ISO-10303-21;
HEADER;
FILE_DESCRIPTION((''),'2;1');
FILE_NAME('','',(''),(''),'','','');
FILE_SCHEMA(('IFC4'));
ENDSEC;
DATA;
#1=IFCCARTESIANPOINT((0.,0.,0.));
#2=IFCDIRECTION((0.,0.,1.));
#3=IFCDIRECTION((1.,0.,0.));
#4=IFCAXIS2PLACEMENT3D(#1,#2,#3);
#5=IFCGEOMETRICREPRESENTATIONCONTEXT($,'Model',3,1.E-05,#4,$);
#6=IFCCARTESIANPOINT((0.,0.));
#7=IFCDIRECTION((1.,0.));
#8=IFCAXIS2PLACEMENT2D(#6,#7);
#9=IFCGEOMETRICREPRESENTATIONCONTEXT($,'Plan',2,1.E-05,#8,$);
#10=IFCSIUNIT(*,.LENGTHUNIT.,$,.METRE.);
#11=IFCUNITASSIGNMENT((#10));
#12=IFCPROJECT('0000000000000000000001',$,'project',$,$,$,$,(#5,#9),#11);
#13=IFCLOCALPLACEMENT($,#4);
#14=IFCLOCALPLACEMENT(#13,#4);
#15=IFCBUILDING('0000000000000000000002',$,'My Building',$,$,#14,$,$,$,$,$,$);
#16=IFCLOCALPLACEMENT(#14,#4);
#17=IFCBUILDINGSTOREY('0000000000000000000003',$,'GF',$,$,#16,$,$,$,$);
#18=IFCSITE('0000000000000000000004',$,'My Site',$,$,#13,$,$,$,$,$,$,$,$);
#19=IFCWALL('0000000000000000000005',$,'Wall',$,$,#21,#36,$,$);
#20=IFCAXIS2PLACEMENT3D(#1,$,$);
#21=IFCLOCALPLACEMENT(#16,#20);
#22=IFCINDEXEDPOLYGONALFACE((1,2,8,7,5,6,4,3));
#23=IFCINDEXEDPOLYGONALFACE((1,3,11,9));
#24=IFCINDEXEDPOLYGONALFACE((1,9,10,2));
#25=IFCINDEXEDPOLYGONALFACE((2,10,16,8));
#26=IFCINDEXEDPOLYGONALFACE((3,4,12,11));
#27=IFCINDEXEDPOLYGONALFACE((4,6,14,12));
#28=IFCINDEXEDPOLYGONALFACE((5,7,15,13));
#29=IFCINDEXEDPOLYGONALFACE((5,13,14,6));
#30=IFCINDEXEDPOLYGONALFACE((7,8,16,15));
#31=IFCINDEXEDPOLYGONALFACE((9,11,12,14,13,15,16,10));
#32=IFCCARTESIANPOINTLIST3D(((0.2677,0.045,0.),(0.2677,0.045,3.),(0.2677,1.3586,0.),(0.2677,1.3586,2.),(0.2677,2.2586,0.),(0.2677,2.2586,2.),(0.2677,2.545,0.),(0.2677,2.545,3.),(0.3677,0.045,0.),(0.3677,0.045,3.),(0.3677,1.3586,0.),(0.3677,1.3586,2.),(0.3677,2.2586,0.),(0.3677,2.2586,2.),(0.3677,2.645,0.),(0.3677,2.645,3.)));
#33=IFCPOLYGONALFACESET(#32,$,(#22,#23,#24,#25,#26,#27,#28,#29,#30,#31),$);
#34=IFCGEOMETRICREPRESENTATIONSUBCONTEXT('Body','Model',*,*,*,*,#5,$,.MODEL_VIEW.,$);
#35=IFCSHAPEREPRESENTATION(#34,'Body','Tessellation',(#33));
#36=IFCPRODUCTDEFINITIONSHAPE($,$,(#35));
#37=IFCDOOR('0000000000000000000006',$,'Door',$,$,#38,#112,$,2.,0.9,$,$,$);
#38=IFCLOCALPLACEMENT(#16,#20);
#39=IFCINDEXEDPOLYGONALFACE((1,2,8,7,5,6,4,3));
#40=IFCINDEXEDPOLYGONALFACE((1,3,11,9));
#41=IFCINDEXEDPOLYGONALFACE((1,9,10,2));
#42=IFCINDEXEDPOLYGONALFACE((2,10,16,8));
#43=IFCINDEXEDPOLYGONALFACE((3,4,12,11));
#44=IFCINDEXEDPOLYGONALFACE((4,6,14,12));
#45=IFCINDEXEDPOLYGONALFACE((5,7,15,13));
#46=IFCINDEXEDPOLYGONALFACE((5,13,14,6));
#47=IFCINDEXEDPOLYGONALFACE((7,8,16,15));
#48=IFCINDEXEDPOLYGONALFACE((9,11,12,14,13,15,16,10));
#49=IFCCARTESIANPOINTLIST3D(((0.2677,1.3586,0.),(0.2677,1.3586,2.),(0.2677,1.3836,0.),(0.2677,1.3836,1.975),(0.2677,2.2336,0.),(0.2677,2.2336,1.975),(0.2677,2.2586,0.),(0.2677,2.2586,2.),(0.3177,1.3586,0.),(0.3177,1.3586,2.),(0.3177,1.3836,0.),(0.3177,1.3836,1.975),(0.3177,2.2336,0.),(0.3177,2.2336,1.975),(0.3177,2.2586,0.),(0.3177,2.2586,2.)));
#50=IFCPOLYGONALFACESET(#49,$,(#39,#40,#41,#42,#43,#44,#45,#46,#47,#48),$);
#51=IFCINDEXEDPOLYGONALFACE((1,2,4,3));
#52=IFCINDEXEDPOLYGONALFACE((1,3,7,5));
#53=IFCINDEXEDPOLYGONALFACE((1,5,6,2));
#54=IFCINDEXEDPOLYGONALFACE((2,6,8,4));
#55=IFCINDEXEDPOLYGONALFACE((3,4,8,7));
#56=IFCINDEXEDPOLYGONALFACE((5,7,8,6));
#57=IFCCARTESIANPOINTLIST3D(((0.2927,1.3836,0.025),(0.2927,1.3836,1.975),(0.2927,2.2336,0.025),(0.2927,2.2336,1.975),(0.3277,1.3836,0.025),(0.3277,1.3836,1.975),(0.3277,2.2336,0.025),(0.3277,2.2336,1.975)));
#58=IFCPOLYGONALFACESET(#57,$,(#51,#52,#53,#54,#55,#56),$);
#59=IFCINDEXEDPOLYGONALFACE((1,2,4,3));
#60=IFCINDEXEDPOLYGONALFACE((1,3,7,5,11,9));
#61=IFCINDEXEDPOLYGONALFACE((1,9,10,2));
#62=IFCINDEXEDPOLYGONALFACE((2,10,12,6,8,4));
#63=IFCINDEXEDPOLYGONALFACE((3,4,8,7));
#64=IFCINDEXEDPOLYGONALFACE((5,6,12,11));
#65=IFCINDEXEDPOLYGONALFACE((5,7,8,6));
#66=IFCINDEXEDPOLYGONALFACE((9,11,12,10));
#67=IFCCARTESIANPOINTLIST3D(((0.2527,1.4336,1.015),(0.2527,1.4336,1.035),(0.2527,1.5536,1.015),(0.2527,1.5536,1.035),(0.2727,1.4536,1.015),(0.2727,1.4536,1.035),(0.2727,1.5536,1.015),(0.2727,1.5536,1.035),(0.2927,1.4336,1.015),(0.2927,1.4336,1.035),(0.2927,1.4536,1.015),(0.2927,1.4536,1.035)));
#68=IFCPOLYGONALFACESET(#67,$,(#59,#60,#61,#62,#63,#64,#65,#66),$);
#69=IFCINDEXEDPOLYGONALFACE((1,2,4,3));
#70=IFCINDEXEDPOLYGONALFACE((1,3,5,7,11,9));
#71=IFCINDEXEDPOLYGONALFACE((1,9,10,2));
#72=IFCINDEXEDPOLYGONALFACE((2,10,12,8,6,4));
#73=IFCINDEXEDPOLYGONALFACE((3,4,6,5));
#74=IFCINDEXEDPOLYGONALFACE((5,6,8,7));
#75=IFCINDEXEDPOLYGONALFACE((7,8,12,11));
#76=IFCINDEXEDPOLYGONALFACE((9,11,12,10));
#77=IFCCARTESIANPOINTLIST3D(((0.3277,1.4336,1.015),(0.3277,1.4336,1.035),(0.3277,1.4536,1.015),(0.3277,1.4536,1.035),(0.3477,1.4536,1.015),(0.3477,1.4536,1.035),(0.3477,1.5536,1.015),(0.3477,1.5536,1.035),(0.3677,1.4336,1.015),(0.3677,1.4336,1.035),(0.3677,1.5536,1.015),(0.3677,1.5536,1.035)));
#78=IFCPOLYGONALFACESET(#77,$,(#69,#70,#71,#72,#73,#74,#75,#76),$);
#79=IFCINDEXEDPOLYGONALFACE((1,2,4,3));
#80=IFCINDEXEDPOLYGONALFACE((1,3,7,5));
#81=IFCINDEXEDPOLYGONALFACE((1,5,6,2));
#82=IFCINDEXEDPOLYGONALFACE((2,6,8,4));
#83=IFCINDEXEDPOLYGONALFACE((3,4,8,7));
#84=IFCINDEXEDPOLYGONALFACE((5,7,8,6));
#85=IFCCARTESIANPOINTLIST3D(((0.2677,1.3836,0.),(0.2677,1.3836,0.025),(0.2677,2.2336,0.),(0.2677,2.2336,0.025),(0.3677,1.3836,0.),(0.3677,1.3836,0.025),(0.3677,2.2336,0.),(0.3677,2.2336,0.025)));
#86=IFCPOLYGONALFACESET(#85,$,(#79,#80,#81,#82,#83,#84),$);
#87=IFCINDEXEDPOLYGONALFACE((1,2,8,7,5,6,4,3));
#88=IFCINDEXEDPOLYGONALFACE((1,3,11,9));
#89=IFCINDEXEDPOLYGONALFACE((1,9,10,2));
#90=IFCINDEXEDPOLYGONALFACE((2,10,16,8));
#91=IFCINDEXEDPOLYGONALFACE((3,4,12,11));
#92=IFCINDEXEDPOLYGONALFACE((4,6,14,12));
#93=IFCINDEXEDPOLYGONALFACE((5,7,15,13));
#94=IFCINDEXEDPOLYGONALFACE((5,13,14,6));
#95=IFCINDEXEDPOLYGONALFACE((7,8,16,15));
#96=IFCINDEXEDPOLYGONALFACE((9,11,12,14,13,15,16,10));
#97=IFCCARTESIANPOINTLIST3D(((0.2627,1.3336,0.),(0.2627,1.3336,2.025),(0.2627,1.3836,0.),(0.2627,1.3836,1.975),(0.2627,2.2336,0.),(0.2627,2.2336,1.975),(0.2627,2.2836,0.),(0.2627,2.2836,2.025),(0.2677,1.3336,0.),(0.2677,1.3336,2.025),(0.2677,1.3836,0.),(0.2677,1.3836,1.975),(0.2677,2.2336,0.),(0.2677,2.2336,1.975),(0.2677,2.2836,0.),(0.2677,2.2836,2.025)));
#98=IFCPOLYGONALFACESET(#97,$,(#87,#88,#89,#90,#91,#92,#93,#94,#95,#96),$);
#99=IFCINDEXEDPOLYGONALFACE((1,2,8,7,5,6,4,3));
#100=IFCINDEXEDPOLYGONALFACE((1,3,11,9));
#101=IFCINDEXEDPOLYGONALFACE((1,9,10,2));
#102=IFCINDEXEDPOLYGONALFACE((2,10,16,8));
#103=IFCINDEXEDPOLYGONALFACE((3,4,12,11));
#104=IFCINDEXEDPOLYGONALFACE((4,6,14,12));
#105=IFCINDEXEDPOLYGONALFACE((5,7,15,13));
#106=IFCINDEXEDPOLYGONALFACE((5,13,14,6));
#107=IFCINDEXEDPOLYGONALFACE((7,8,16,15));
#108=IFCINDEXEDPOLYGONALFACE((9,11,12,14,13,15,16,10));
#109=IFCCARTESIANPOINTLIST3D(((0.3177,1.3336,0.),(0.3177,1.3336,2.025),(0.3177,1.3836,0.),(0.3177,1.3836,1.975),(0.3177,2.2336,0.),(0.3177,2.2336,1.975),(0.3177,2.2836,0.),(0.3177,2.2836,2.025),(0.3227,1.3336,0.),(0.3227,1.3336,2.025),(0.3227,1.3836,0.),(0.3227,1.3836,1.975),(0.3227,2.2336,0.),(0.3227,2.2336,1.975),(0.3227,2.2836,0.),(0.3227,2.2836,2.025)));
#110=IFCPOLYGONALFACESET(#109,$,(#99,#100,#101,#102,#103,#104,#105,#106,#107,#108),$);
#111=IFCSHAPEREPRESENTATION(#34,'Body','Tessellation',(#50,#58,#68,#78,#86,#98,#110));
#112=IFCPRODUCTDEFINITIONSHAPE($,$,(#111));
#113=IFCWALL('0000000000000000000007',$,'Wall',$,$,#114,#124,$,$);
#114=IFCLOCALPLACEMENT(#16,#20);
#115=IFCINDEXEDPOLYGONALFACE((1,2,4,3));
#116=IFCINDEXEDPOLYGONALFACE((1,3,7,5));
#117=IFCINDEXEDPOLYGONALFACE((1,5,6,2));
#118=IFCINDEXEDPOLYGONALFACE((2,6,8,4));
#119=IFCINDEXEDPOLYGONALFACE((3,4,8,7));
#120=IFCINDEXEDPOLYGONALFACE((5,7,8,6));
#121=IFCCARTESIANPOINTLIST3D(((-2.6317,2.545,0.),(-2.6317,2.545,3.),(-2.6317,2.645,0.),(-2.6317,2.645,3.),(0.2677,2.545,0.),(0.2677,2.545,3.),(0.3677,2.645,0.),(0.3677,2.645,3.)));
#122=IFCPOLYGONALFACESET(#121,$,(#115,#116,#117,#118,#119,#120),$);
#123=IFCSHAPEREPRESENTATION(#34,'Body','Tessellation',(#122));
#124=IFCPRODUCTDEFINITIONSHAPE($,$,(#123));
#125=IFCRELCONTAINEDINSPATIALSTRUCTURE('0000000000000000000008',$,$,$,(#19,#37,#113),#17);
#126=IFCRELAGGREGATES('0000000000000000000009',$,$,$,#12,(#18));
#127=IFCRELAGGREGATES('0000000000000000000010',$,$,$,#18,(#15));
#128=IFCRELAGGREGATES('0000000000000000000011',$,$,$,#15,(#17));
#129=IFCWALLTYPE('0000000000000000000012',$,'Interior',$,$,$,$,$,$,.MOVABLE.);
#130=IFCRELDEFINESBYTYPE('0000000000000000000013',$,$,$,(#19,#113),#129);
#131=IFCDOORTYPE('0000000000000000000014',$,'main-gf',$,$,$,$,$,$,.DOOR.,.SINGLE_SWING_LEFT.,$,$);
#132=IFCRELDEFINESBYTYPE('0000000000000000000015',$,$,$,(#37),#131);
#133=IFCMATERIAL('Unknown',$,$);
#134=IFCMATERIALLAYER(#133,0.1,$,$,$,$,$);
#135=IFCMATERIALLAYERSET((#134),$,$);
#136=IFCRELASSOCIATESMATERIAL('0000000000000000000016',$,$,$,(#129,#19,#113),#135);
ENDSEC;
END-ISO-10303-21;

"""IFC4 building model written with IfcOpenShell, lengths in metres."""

from ifc_helpers import new_model, entity, si_unit, frame, origin_with_axes, origin_2d_with_axis, place, context, subcontext, project, spatial, line, indexed_curve, outline, extrude, shape, source, transform, mapped, material, layer, layer_set, layer_usage, type_object, type_shapes, element, fill, save


model = new_model("IFC4")

# Units and contexts
model_context = context("Model", 3, precision=1e-05, world=origin_with_axes())
plan_context = context("Plan", 2, precision=1e-05, world=origin_2d_with_axis())
body_context_1 = subcontext(model_context, "Body", "Model", "MODEL_VIEW")
body_context_2 = subcontext(plan_context, "Body", "Plan", "PLAN_VIEW")
ifc_project = project(units=[si_unit("LENGTHUNIT", "METRE")], contexts=[model_context, plan_context])

# Site, building, storey
site_placement = place(None, origin_with_axes())
site = spatial("IfcSite", under=ifc_project, at=site_placement, Name="My Site")
building_placement = place(site_placement, origin_with_axes())
building = spatial("IfcBuilding", under=site, at=building_placement, Name="My Building")
storey_placement = place(building_placement, origin_with_axes())
storey = spatial("IfcBuildingStorey", under=building, at=storey_placement, Name="GF")

# Shared definitions
ifc_material = material(Name="Unknown")

# Shared definitions
shared_shape_1 = source(origin_with_axes(), body_context_1, "Body", "SweptSolid", [
    extrude(outline(indexed_curve([(0.0, 0.0), (0.9, 0.0), (0.9, 2.0), (0.0, 2.0)], segments=[line(1, 2, 3, 4, 1)])), frame((0.0, -0.6, 0.0), z_axis=(0.0, -1.0, 0.0), x_axis=(1.0, 0.0, 0.0)), (0.0, 0.0, -1.0), 1.2),
])
door_type = type_object("IfcDoorType", Name="main-gf", OperationType="SINGLE_SWING_LEFT", PredefinedType="DOOR")
shared_shape_2 = source(origin_with_axes(), body_context_1, "Body", "SweptSolid", [
    extrude(outline(indexed_curve([(0.0, 0.0), (0.0, 2.0), (0.9, 2.0), (0.9, 0.0), (0.875, 0.0), (0.875, 1.975), (0.025, 1.975), (0.025, 0.0)], segments=[line(1, 2, 3, 4, 5, 6, 7, 8, 1)])), frame((0.0, 0.0, 0.0), z_axis=(0.0, -1.0, 0.0), x_axis=(1.0, 0.0, 0.0)), (0.0, 0.0, -1.0), 0.05),
    extrude(outline(indexed_curve([(0.0, 0.0), (0.85, 0.0), (0.85, 0.035), (0.0, 0.035)], segments=[line(1, 2, 3, 4, 1)])), frame((0.025, 0.025, 0.025), z_axis=(0.0, 0.0, 1.0), x_axis=(1.0, 0.0, 0.0)), (0.0, 0.0, 1.0), 1.95),
    extrude(outline(indexed_curve([(0.0, 0.0), (0.0, -0.04), (-0.12, -0.04), (-0.12, -0.02), (-0.02, -0.02), (-0.02, 0.0)], segments=[line(1, 2, 3, 4, 5, 6, 1)])), frame((0.825, 0.025, 1.015), z_axis=(0.0, 0.0, 1.0), x_axis=(1.0, 0.0, 0.0)), (0.0, 0.0, 1.0), 0.02),
    extrude(outline(indexed_curve([(0.0, 0.0), (0.0, 0.04), (-0.12, 0.04), (-0.12, 0.02), (-0.02, 0.02), (-0.02, 0.0)], segments=[line(1, 2, 3, 4, 5, 6, 1)])), frame((0.825, 0.06, 1.015), z_axis=(0.0, 0.0, 1.0), x_axis=(1.0, 0.0, 0.0)), (0.0, 0.0, 1.0), 0.02),
    extrude(outline(indexed_curve([(0.0, 0.0), (0.85, 0.0), (0.85, 0.1), (0.0, 0.1)], segments=[line(1, 2, 3, 4, 1)])), frame((0.025, 0.0, 0.0), z_axis=(0.0, 0.0, 1.0), x_axis=(1.0, 0.0, 0.0)), (0.0, 0.0, 1.0), 0.025),
    extrude(outline(indexed_curve([(0.0, 0.0), (0.0, 2.025), (0.95, 2.025), (0.95, 0.0), (0.9, 0.0), (0.9, 1.975), (0.05, 1.975), (0.05, 0.0)], segments=[line(1, 2, 3, 4, 5, 6, 7, 8, 1)])), frame((-0.025, -0.005, 0.0), z_axis=(0.0, -1.0, 0.0), x_axis=(1.0, 0.0, 0.0)), (0.0, 0.0, -1.0), 0.005),
    extrude(outline(indexed_curve([(0.0, 0.0), (0.0, 2.025), (0.95, 2.025), (0.95, 0.0), (0.9, 0.0), (0.9, 1.975), (0.05, 1.975), (0.05, 0.0)], segments=[line(1, 2, 3, 4, 5, 6, 7, 8, 1)])), frame((-0.025, 0.05, 0.0), z_axis=(0.0, -1.0, 0.0), x_axis=(1.0, 0.0, 0.0)), (0.0, 0.0, -1.0), 0.005),
])
shared_shape_3 = source(origin_with_axes(), body_context_2, "Body", "Curve2D", [
    entity("IfcIndexedPolyCurve", entity("IfcCartesianPointList2D", [[0.0, 0.0], [0.025, 0.0], [0.025, 0.05], [0.0, 0.05]]), [entity("IfcLineIndex", [1, 2, 3, 4, 1])]),
    entity("IfcIndexedPolyCurve", entity("IfcCartesianPointList2D", [[0.9, 0.0], [0.875, 0.0], [0.875, 0.05], [0.9, 0.05]]), [entity("IfcLineIndex", [1, 2, 3, 4, 1])]),
    entity("IfcIndexedPolyCurve", entity("IfcCartesianPointList2D", [[0.025, 0.05], [0.025, -0.8], [0.06, -0.8]])),
    entity("IfcTrimmedCurve", entity("IfcEllipse", entity("IfcAxis2Placement2D", entity("IfcCartesianPoint", [0.06, 0.05]), entity("IfcDirection", [1.0, 0.0])), 0.815, 0.85), [entity("IfcCartesianPoint", [0.06, -0.8])], [entity("IfcCartesianPoint", [0.06, 0.9])], True, "CARTESIAN"),
    entity("IfcIndexedPolyCurve", entity("IfcCartesianPointList2D", [[0.025, 0.05], [0.06, 0.05], [0.06, 0.9], [0.025, 0.9]]), [entity("IfcLineIndex", [1, 2, 3, 4, 1])]),
])
type_shapes(door_type, [shared_shape_2, shared_shape_3])

# Wall, opening, door
ifc_layer_1 = layer(ifc_material, 0.1)
ifc_layer_set_1 = layer_set([ifc_layer_1])
ifc_layer_usage_1 = layer_usage(ifc_layer_set_1, "AXIS2", "POSITIVE", 0.0)
wall_type_1 = type_object("IfcWallType", Name="Interior", PredefinedType="MOVABLE", material=ifc_layer_set_1)
wall_1_placement = place(storey_placement, frame((0.3677, 0.045, 0.0), z_axis=(0.0, 0.0, 1.0), x_axis=(0.0, 1.0, 0.0)))
wall_1 = element("IfcWall", 1, at=wall_1_placement, inside=storey, type_object=wall_type_1, material=ifc_layer_usage_1, Name="Wall", context=body_context_1, shape_type="SweptSolid", body=[
    extrude(outline(indexed_curve([(0.0, 0.0), (0.0, 0.1), (2.5, 0.1), (2.6, 0.0)], segments=[line(1, 2, 3, 4, 1)])), origin_with_axes(), (0.0, 0.0, 1.0), 3.0),
])
opening_1_placement = place(wall_1_placement, frame((2.2136, 0.1, 0.0), z_axis=(0.0, 0.0, 1.0), x_axis=(-1.0, 0.0, 0.0)))
opening_1 = element("IfcOpeningElement", 2, at=opening_1_placement, cuts=wall_1, PredefinedType="OPENING", context=body_context_1, shape_type="MappedRepresentation", body=[
    mapped(shared_shape_1, transform((0.0, 0.0, 0.0), x_axis=(1.0, 0.0, 0.0), y_axis=(0.0, 1.0, 0.0), z_axis=(0.0, 0.0, 1.0), scale=1.0)),
])
door_1_placement = place(opening_1_placement, frame((0.0, 0.0, 0.0), z_axis=(0.0, 0.0, 1.0), x_axis=(1.0, 0.0, 0.0)))
door_1 = element("IfcDoor", 3, at=door_1_placement, inside=storey, type_object=door_type, Name="Door", OverallHeight=2.0, OverallWidth=0.9, shapes=[
    shape(body_context_1, "Body", "MappedRepresentation", [mapped(shared_shape_2, transform((0.0, 0.0, 0.0), x_axis=(1.0, 0.0, 0.0), y_axis=(0.0, 1.0, 0.0), z_axis=(0.0, 0.0, 1.0), scale=1.0))]),
    shape(body_context_2, "Body", "MappedRepresentation", [mapped(shared_shape_3, transform((0.0, 0.0, 0.0), x_axis=(1.0, 0.0, 0.0), y_axis=(0.0, 1.0, 0.0), z_axis=(0.0, 0.0, 1.0), scale=1.0))]),
])
fill(opening_1, door_1)

# Wall
ifc_layer_usage_2 = layer_usage(ifc_layer_set_1, "AXIS2", "POSITIVE", 0.0)
wall_2_placement = place(storey_placement, frame((0.3677, 2.645, 0.0), z_axis=(0.0, 0.0, 1.0), x_axis=(-1.0, 0.0, 0.0)))
element("IfcWall", 4, at=wall_2_placement, inside=storey, type_object=wall_type_1, material=ifc_layer_usage_2, Name="Wall", context=body_context_1, shape_type="SweptSolid", body=[
    extrude(outline(indexed_curve([(0.0, 0.0), (0.1, 0.1), (2.9994, 0.1), (2.9994, 0.0)], segments=[line(1, 2, 3, 4, 1)])), origin_with_axes(), (0.0, 0.0, 1.0), 3.0),
])

save(model, "model.ifc")
